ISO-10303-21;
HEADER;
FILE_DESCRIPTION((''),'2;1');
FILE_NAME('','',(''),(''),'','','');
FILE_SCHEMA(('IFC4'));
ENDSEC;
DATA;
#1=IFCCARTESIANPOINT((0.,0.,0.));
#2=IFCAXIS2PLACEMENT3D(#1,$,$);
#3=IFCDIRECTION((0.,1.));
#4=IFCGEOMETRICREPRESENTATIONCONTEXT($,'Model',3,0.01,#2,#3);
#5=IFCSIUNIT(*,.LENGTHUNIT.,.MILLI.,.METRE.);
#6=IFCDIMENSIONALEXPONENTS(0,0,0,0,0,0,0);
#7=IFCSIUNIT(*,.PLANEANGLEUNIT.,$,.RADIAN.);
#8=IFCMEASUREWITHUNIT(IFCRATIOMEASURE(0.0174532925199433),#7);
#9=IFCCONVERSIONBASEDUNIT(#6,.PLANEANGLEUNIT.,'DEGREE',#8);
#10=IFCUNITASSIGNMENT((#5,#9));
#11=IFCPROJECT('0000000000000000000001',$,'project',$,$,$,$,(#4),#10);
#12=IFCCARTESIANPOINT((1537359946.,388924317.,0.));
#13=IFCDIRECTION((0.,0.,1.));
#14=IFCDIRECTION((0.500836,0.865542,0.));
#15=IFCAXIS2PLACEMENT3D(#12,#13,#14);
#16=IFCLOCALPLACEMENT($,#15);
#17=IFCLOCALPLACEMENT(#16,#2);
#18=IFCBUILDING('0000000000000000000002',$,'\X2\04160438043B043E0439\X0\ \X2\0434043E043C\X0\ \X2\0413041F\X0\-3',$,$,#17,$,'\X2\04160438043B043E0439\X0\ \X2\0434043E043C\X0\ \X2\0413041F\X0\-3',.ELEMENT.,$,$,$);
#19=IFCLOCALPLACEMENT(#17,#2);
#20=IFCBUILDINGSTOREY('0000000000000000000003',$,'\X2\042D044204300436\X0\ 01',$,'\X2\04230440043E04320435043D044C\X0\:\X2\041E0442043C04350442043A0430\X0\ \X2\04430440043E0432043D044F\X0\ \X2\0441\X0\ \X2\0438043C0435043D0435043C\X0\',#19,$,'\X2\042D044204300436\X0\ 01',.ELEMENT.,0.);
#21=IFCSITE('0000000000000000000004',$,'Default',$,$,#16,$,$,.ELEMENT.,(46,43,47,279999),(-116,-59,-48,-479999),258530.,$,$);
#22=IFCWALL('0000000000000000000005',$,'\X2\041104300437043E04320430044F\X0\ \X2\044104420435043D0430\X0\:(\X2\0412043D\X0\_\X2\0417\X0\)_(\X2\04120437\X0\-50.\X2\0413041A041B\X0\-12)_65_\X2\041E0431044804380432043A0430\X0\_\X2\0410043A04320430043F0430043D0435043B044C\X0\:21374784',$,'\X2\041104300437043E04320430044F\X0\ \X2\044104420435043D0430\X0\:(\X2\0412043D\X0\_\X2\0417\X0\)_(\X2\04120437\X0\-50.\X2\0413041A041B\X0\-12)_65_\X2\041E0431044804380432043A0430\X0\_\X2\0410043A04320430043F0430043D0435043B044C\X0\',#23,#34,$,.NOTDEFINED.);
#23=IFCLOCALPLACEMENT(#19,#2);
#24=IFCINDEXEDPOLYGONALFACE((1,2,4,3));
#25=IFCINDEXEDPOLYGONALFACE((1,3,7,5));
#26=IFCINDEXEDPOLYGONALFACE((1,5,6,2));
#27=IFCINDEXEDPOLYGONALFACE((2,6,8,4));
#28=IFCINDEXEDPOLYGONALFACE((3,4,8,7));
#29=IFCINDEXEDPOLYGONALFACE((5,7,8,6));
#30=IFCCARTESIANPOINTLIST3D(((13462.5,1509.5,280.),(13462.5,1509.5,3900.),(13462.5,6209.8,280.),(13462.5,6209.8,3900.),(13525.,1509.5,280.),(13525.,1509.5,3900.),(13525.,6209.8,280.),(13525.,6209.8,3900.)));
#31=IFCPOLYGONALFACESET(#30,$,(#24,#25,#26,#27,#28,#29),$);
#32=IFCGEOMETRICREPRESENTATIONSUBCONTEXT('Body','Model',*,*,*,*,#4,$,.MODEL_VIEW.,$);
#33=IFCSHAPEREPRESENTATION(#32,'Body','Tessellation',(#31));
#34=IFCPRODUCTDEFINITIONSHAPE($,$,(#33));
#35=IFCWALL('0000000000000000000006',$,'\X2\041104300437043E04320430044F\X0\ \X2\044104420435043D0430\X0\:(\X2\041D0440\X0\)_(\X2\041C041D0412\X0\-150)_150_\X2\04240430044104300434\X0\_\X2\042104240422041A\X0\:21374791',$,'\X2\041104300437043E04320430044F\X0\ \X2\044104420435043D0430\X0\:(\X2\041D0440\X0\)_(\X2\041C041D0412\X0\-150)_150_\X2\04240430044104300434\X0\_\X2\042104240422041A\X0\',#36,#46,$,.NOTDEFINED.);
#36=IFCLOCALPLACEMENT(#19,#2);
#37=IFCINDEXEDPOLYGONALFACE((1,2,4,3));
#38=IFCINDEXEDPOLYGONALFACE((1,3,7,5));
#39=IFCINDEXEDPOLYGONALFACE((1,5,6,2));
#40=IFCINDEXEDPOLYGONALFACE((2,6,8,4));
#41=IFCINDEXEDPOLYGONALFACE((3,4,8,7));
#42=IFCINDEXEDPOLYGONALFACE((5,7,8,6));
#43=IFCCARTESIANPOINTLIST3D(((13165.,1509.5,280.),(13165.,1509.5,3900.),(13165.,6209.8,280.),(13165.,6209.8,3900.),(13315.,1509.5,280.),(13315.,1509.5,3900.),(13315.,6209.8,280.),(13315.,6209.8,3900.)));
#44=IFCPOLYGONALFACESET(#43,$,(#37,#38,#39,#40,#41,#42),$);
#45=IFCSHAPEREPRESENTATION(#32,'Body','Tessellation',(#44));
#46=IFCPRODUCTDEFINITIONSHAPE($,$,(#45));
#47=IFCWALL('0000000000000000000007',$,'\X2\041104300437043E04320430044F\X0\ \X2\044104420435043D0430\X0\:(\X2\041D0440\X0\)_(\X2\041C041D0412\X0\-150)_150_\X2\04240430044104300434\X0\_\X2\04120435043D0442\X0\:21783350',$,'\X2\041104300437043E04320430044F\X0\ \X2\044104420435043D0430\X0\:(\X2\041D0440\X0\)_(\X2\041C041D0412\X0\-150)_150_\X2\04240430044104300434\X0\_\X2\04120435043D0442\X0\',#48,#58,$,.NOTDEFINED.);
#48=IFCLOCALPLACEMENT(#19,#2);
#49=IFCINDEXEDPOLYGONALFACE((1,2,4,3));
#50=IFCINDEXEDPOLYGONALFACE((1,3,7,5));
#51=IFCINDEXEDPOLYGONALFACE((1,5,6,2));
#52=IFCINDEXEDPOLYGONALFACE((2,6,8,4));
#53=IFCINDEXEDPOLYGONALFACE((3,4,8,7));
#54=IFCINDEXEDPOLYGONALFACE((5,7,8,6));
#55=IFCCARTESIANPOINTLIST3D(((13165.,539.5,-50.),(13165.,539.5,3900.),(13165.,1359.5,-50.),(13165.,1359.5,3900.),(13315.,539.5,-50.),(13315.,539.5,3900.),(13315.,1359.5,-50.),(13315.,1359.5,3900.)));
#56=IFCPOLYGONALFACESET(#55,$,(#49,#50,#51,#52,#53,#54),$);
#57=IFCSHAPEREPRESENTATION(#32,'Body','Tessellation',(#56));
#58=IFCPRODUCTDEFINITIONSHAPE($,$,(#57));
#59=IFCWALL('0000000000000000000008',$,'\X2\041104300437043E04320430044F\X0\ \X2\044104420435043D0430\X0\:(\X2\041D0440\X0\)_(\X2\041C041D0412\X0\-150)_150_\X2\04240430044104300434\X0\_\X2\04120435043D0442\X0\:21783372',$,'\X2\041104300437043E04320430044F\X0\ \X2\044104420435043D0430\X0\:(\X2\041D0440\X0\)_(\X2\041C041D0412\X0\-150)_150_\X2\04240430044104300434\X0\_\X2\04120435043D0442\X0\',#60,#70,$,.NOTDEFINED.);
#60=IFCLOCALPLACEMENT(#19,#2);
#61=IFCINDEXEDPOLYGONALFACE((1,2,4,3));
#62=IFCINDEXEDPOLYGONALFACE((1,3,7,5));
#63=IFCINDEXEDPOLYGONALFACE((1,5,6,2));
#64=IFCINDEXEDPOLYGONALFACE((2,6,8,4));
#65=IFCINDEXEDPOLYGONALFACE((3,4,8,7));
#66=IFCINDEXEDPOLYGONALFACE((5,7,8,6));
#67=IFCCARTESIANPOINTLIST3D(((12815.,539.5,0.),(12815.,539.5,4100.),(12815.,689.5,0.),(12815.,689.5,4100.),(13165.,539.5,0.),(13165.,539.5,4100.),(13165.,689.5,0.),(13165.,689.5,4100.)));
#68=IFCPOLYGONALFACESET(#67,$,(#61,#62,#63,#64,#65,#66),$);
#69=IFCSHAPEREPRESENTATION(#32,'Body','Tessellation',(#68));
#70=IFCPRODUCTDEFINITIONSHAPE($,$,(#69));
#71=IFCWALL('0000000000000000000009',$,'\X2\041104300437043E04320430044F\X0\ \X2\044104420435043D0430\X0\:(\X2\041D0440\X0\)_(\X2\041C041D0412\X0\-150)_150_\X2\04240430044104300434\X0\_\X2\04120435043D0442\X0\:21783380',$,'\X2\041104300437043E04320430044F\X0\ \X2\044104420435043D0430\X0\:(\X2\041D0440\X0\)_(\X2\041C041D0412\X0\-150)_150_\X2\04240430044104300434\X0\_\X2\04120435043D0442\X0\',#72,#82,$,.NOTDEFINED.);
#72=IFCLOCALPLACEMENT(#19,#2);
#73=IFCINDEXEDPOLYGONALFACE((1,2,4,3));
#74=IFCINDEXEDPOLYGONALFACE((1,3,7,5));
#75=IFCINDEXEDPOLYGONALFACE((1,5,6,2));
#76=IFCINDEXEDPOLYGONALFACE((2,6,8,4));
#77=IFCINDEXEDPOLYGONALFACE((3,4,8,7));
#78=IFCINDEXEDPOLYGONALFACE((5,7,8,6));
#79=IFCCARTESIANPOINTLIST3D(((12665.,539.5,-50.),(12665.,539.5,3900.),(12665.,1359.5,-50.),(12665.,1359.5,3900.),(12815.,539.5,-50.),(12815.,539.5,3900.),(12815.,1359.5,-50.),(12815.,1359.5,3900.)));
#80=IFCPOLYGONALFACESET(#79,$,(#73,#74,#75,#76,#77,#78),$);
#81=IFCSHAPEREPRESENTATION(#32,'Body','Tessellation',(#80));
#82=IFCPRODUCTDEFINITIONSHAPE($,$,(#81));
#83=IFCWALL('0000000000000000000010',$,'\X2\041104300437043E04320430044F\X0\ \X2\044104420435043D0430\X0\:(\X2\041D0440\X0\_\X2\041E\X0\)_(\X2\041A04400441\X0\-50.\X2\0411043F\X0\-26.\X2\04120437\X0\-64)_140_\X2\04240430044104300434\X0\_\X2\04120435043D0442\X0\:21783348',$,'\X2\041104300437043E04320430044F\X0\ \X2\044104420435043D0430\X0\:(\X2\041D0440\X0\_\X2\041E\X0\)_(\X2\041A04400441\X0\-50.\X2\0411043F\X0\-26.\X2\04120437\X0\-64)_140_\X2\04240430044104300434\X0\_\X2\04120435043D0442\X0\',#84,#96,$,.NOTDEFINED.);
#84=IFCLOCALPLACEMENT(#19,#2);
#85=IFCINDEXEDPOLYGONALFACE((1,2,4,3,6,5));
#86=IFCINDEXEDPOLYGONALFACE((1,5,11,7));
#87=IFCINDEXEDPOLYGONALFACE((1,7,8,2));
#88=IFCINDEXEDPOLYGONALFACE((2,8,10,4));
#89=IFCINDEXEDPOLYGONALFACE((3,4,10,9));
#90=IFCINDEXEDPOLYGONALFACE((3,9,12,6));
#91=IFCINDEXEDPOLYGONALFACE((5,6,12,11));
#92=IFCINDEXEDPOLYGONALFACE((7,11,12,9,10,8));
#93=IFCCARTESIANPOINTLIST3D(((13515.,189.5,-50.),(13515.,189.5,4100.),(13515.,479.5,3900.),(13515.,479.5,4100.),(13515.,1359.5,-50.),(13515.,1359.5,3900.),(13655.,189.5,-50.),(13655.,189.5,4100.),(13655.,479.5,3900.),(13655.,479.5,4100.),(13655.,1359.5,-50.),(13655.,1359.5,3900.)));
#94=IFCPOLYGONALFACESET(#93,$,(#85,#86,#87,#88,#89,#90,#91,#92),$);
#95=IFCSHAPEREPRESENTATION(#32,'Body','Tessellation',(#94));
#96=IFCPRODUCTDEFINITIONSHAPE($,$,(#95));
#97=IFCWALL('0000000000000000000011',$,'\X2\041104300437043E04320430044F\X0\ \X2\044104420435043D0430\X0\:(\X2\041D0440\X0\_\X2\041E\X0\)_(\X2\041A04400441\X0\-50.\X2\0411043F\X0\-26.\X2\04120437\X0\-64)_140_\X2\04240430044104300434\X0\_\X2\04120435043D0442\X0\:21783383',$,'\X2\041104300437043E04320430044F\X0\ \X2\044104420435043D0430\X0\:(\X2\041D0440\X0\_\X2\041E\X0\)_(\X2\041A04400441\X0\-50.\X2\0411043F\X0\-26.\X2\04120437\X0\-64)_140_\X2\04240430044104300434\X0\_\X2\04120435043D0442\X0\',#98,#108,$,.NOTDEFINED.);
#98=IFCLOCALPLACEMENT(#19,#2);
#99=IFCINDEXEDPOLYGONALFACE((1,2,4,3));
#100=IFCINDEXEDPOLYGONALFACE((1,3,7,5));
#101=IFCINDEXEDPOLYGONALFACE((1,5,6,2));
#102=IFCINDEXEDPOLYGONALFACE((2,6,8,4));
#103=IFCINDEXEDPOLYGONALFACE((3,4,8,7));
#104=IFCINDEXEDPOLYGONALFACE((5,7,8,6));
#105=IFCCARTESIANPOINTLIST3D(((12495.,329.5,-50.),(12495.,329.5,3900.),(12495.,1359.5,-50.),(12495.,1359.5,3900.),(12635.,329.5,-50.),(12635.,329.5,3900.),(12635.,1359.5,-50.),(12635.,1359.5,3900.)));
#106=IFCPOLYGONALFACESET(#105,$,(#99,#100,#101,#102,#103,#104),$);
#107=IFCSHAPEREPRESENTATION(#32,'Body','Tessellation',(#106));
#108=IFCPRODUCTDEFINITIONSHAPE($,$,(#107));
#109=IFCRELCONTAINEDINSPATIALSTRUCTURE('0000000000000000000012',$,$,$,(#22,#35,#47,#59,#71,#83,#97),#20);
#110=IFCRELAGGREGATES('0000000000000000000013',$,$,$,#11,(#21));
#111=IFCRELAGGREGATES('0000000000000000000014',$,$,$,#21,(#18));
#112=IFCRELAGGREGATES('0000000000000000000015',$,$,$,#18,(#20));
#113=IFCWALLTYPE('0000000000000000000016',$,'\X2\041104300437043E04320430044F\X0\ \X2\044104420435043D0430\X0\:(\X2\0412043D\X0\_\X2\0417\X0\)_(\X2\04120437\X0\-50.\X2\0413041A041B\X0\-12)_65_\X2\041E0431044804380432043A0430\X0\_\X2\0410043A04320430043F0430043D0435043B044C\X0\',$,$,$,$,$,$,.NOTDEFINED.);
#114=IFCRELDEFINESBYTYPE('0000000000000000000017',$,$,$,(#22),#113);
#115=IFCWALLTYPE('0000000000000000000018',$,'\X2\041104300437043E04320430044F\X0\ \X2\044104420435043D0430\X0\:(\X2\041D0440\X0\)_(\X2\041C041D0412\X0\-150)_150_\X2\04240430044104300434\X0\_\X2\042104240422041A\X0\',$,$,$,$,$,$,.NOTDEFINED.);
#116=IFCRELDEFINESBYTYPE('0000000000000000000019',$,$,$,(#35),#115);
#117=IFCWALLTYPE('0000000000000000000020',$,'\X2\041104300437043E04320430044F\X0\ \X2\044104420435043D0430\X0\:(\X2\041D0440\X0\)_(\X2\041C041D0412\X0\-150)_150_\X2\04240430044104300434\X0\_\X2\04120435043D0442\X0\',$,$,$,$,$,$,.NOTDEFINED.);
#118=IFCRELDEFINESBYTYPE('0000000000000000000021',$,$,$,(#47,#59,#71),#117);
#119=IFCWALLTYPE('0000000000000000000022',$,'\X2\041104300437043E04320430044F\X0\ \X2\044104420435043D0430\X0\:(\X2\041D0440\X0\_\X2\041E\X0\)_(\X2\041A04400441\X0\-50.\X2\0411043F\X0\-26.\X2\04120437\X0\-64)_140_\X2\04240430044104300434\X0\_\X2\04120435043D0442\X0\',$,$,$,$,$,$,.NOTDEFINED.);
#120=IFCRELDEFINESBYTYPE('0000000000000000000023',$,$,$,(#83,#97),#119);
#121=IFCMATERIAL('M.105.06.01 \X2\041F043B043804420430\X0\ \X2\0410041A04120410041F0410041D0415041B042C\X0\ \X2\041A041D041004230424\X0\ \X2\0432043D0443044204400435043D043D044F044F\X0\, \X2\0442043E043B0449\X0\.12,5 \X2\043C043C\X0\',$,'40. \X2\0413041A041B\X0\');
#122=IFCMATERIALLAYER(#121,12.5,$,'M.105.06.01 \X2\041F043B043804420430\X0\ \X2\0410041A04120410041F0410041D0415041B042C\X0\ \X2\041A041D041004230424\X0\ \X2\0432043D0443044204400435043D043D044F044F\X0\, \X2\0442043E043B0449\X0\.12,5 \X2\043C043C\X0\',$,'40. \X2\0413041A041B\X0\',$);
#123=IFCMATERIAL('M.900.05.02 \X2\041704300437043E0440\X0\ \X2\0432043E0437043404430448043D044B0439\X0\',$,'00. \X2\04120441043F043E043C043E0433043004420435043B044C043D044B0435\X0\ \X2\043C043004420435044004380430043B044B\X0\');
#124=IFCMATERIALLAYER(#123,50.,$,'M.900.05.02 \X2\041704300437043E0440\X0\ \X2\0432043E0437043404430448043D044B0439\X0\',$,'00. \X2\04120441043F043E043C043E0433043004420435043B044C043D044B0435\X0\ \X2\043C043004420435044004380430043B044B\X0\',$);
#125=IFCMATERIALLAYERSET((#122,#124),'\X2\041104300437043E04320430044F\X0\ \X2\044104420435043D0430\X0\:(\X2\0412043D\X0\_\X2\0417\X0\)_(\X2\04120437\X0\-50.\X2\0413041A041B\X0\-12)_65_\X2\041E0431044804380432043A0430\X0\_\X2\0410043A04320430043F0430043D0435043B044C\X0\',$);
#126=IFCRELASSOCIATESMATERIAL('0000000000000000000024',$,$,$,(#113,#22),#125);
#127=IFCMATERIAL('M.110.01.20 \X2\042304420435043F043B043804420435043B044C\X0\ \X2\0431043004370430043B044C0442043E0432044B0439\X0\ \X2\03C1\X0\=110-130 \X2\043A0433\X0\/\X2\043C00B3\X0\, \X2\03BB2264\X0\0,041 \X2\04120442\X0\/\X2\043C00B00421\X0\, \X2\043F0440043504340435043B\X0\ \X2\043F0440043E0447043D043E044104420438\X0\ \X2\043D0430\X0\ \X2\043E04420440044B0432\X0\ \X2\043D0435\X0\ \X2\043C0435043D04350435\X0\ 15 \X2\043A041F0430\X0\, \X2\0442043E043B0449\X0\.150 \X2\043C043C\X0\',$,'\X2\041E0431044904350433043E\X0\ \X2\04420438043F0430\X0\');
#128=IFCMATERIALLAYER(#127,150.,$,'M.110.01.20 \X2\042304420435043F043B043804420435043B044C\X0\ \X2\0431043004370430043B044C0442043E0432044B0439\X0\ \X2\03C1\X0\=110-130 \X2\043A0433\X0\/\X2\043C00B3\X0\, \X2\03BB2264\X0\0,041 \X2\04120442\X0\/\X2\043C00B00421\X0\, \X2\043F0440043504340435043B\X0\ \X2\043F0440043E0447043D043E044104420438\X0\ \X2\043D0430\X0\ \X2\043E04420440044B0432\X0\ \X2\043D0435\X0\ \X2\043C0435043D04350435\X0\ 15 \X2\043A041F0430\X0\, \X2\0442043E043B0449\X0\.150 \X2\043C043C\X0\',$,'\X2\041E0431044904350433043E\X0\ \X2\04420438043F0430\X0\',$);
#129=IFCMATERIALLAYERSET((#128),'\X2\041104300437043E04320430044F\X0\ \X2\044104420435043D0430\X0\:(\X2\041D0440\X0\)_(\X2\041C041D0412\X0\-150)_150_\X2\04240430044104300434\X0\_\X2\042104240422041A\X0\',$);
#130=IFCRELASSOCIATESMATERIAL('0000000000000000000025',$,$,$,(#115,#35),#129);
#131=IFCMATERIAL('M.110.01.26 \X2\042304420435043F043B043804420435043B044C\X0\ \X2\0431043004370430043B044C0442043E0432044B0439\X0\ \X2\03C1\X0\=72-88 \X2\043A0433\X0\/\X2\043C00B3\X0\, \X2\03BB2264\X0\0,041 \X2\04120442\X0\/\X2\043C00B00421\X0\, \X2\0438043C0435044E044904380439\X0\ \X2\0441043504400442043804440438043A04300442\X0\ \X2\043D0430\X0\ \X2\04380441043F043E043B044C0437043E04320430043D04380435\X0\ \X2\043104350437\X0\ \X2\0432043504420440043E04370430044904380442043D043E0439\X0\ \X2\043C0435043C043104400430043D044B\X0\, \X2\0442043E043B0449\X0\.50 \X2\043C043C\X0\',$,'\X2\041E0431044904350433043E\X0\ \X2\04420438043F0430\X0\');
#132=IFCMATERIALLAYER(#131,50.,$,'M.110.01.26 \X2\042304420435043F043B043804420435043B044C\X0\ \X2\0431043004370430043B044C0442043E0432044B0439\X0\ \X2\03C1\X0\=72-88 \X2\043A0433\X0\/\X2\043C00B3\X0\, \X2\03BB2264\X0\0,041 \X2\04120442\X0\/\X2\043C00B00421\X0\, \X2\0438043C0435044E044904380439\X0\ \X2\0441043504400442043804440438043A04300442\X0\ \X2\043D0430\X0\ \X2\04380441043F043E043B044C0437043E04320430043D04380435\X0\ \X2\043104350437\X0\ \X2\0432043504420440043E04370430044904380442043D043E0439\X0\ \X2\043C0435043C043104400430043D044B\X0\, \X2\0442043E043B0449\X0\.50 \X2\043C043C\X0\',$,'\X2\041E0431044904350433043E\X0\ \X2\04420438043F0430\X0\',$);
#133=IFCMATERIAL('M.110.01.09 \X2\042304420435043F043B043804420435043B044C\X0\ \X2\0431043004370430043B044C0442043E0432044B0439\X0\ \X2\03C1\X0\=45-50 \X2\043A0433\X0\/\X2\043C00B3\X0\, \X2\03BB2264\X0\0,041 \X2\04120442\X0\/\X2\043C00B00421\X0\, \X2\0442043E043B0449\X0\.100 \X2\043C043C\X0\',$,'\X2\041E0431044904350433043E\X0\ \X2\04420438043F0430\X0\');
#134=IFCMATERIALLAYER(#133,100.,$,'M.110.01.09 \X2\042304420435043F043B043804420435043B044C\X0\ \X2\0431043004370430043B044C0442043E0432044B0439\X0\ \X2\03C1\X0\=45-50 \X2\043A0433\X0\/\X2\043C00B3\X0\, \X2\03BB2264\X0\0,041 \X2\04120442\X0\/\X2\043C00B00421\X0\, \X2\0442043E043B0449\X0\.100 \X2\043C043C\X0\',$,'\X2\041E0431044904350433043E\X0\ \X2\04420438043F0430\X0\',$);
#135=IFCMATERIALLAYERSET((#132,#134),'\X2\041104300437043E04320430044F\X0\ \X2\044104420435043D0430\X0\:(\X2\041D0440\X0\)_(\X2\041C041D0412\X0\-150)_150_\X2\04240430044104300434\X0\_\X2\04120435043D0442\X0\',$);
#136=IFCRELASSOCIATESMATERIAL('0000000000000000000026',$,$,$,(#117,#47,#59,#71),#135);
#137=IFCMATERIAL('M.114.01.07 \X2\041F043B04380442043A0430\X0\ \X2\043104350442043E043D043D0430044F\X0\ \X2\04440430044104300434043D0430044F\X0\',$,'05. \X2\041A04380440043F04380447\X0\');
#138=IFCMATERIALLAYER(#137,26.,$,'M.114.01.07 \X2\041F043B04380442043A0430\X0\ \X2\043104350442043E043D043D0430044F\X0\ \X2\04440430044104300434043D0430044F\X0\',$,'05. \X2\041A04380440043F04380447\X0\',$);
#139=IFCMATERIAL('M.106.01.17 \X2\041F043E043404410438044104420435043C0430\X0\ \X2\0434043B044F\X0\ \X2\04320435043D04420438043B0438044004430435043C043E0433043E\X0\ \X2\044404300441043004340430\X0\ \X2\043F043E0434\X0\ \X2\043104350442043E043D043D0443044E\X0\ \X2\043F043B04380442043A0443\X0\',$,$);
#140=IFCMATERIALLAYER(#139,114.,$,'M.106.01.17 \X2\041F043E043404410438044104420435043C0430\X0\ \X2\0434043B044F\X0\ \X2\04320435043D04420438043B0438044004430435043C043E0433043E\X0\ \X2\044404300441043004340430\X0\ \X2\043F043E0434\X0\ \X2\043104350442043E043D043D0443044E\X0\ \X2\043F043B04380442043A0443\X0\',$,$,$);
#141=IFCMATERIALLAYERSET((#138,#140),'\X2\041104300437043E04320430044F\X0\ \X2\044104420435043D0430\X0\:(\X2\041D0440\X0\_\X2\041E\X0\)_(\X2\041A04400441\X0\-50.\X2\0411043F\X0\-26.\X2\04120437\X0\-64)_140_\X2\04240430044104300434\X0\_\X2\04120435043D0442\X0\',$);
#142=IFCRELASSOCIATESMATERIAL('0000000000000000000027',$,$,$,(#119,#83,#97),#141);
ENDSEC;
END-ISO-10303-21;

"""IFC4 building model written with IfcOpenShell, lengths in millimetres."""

from ifc_helpers import new_model, entity, si_unit, converted_unit, direction, frame, frame_2d, origin, place, context, subcontext, project, spatial, rectangle, extrude, material, layer, layer_set, layer_usage, type_object, element, save


model = new_model("IFC4")

# Units and contexts
model_context = context("Model", 3, precision=0.01, world=origin(), true_north=direction((0.0, 1.0)))
body_context = subcontext(model_context, "Body", "Model", "MODEL_VIEW")
ifc_project = project(units=[si_unit("LENGTHUNIT", "METRE", prefix="MILLI"), converted_unit("PLANEANGLEUNIT", "DEGREE", entity("IfcRatioMeasure", 0.0174532925199433), si_unit("PLANEANGLEUNIT", "RADIAN"), dimensions=[0, 0, 0, 0, 0, 0, 0])], contexts=[model_context])

# Site, building, storey
site_placement = place(None, frame((1537359946.0, 388924317.0, 0.0), z_axis=(0.0, 0.0, 1.0), x_axis=(0.500836, 0.865542, 0.0)))
site = spatial("IfcSite", under=ifc_project, at=site_placement, Name="Default", CompositionType="ELEMENT", RefLatitude=(46, 43, 47, 279999), RefLongitude=(-116, -59, -48, -479999), RefElevation=258530.0)
building_placement = place(site_placement, origin())
building = spatial("IfcBuilding", under=site, at=building_placement, Name="Жилой дом ГП-3", LongName="Жилой дом ГП-3", CompositionType="ELEMENT")
storey_placement = place(building_placement, origin())
storey = spatial("IfcBuildingStorey", under=building, at=storey_placement, Name="Этаж 01", ObjectType="Уровень:Отметка уровня с именем", LongName="Этаж 01", CompositionType="ELEMENT", Elevation=0.0)

# Walls
ifc_material_1 = material(Name="M.105.06.01 Плита АКВАПАНЕЛЬ КНАУФ внутренняя, толщ.12,5 мм", Category="40. ГКЛ")
ifc_layer_1 = layer(ifc_material_1, 12.5, Name="M.105.06.01 Плита АКВАПАНЕЛЬ КНАУФ внутренняя, толщ.12,5 мм", Category="40. ГКЛ")
ifc_material_2 = material(Name="M.900.05.02 Зазор воздушный", Category="00. Вспомогательные материалы")
ifc_layer_2 = layer(ifc_material_2, 50.0, Name="M.900.05.02 Зазор воздушный", Category="00. Вспомогательные материалы")
ifc_layer_set_1 = layer_set([ifc_layer_1, ifc_layer_2], Name="Базовая стена:(Вн_З)_(Вз-50.ГКЛ-12)_65_Обшивка_Аквапанель")
ifc_layer_usage_1 = layer_usage(ifc_layer_set_1, "AXIS2", "POSITIVE", -31.2)
wall_type_1 = type_object("IfcWallType", Name="Базовая стена:(Вн_З)_(Вз-50.ГКЛ-12)_65_Обшивка_Аквапанель", PredefinedType="NOTDEFINED", material=ifc_layer_set_1)
wall_1_placement = place(storey_placement, frame((13493.7, 1509.5, 280.0), z_axis=(0.0, 0.0, 1.0), x_axis=(0.0, 1.0, 0.0)))
element("IfcWall", 1, at=wall_1_placement, inside=storey, type_object=wall_type_1, material=ifc_layer_usage_1, Name="Базовая стена:(Вн_З)_(Вз-50.ГКЛ-12)_65_Обшивка_Аквапанель:21374784", ObjectType="Базовая стена:(Вн_З)_(Вз-50.ГКЛ-12)_65_Обшивка_Аквапанель", PredefinedType="NOTDEFINED", context=body_context, shape_type="SweptSolid", body=[
    extrude(rectangle(XDim=4700.2, YDim=62.5, at=frame_2d((2350.1, 0.0), x_axis=(-1.0, 0.0))), origin(), (0.0, 0.0, 1.0), 3620.0),
])
ifc_material_3 = material(Name="M.110.01.20 Утеплитель базальтовый ρ=110-130 кг/м³, λ≤0,041 Вт/м°С, предел прочности на отрыв не менее 15 кПа, толщ.150 мм", Category="Общего типа")
ifc_layer_3 = layer(ifc_material_3, 150.0, Name="M.110.01.20 Утеплитель базальтовый ρ=110-130 кг/м³, λ≤0,041 Вт/м°С, предел прочности на отрыв не менее 15 кПа, толщ.150 мм", Category="Общего типа")
ifc_layer_set_2 = layer_set([ifc_layer_3], Name="Базовая стена:(Нр)_(МНВ-150)_150_Фасад_СФТК")
ifc_layer_usage_2 = layer_usage(ifc_layer_set_2, "AXIS2", "NEGATIVE", 75.0)
wall_type_2 = type_object("IfcWallType", Name="Базовая стена:(Нр)_(МНВ-150)_150_Фасад_СФТК", PredefinedType="NOTDEFINED", material=ifc_layer_set_2)
wall_2_placement = place(storey_placement, frame((13240.0, 1509.5, 280.0), z_axis=(0.0, 0.0, 1.0), x_axis=(0.0, 1.0, 0.0)))
element("IfcWall", 2, at=wall_2_placement, inside=storey, type_object=wall_type_2, material=ifc_layer_usage_2, Name="Базовая стена:(Нр)_(МНВ-150)_150_Фасад_СФТК:21374791", ObjectType="Базовая стена:(Нр)_(МНВ-150)_150_Фасад_СФТК", PredefinedType="NOTDEFINED", context=body_context, shape_type="SweptSolid", body=[
    extrude(rectangle(XDim=4700.2, YDim=150.0, at=frame_2d((2350.1, 0.0), x_axis=(-1.0, 0.0))), origin(), (0.0, 0.0, 1.0), 3620.0),
])
ifc_material_4 = material(Name="M.110.01.26 Утеплитель базальтовый ρ=72-88 кг/м³, λ≤0,041 Вт/м°С, имеющий сертификат на использование без ветрозащитной мембраны, толщ.50 мм", Category="Общего типа")
ifc_layer_4 = layer(ifc_material_4, 50.0, Name="M.110.01.26 Утеплитель базальтовый ρ=72-88 кг/м³, λ≤0,041 Вт/м°С, имеющий сертификат на использование без ветрозащитной мембраны, толщ.50 мм", Category="Общего типа")
ifc_material_5 = material(Name="M.110.01.09 Утеплитель базальтовый ρ=45-50 кг/м³, λ≤0,041 Вт/м°С, толщ.100 мм", Category="Общего типа")
ifc_layer_5 = layer(ifc_material_5, 100.0, Name="M.110.01.09 Утеплитель базальтовый ρ=45-50 кг/м³, λ≤0,041 Вт/м°С, толщ.100 мм", Category="Общего типа")
ifc_layer_set_3 = layer_set([ifc_layer_4, ifc_layer_5], Name="Базовая стена:(Нр)_(МНВ-150)_150_Фасад_Вент")
ifc_layer_usage_3 = layer_usage(ifc_layer_set_3, "AXIS2", "NEGATIVE", 75.0)
wall_type_3 = type_object("IfcWallType", Name="Базовая стена:(Нр)_(МНВ-150)_150_Фасад_Вент", PredefinedType="NOTDEFINED", material=ifc_layer_set_3)
wall_3_placement = place(storey_placement, frame((13240.0, 1359.5, -50.0), z_axis=(0.0, 0.0, 1.0), x_axis=(0.0, -1.0, 0.0)))
element("IfcWall", 3, at=wall_3_placement, inside=storey, type_object=wall_type_3, material=ifc_layer_usage_3, Name="Базовая стена:(Нр)_(МНВ-150)_150_Фасад_Вент:21783350", ObjectType="Базовая стена:(Нр)_(МНВ-150)_150_Фасад_Вент", PredefinedType="NOTDEFINED", context=body_context, shape_type="SweptSolid", body=[
    extrude(rectangle(XDim=820.0, YDim=150.0, at=frame_2d((410.0, 0.0), x_axis=(-1.0, 0.0))), origin(), (0.0, 0.0, 1.0), 3950.0),
])
ifc_layer_usage_4 = layer_usage(ifc_layer_set_3, "AXIS2", "NEGATIVE", 75.0)
wall_4_placement = place(storey_placement, frame((13165.0, 614.5, 0.0), z_axis=(0.0, 0.0, 1.0), x_axis=(-1.0, 0.0, 0.0)))
element("IfcWall", 4, at=wall_4_placement, inside=storey, type_object=wall_type_3, material=ifc_layer_usage_4, Name="Базовая стена:(Нр)_(МНВ-150)_150_Фасад_Вент:21783372", ObjectType="Базовая стена:(Нр)_(МНВ-150)_150_Фасад_Вент", PredefinedType="NOTDEFINED", context=body_context, shape_type="SweptSolid", body=[
    extrude(rectangle(XDim=350.0, YDim=150.0, at=frame_2d((175.0, 0.0), x_axis=(-1.0, 0.0))), origin(), (0.0, 0.0, 1.0), 4100.0),
])
ifc_layer_usage_5 = layer_usage(ifc_layer_set_3, "AXIS2", "POSITIVE", -75.0)
wall_5_placement = place(storey_placement, frame((12740.0, 1359.5, -50.0), z_axis=(0.0, 0.0, 1.0), x_axis=(0.0, -1.0, 0.0)))
element("IfcWall", 5, at=wall_5_placement, inside=storey, type_object=wall_type_3, material=ifc_layer_usage_5, Name="Базовая стена:(Нр)_(МНВ-150)_150_Фасад_Вент:21783380", ObjectType="Базовая стена:(Нр)_(МНВ-150)_150_Фасад_Вент", PredefinedType="NOTDEFINED", context=body_context, shape_type="SweptSolid", body=[
    extrude(rectangle(XDim=820.0, YDim=150.0, at=frame_2d((410.0, 0.0), x_axis=(-1.0, 0.0))), origin(), (0.0, 0.0, 1.0), 3950.0),
])

# Wall, opening
ifc_material_6 = material(Name="M.114.01.07 Плитка бетонная фасадная", Category="05. Кирпич")
ifc_layer_6 = layer(ifc_material_6, 26.0, Name="M.114.01.07 Плитка бетонная фасадная", Category="05. Кирпич")
ifc_material_7 = material(Name="M.106.01.17 Подсистема для вентилируемого фасада под бетонную плитку")
ifc_layer_7 = layer(ifc_material_7, 114.0, Name="M.106.01.17 Подсистема для вентилируемого фасада под бетонную плитку")
ifc_layer_set_4 = layer_set([ifc_layer_6, ifc_layer_7], Name="Базовая стена:(Нр_О)_(Крс-50.Бп-26.Вз-64)_140_Фасад_Вент")
ifc_layer_usage_6 = layer_usage(ifc_layer_set_4, "AXIS2", "POSITIVE", -70.0)
wall_type_4 = type_object("IfcWallType", Name="Базовая стена:(Нр_О)_(Крс-50.Бп-26.Вз-64)_140_Фасад_Вент", PredefinedType="NOTDEFINED", material=ifc_layer_set_4)
wall_6_placement = place(storey_placement, frame((13585.0, 189.5, -50.0), z_axis=(0.0, 0.0, 1.0), x_axis=(0.0, 1.0, 0.0)))
wall_6 = element("IfcWall", 6, at=wall_6_placement, inside=storey, type_object=wall_type_4, material=ifc_layer_usage_6, Name="Базовая стена:(Нр_О)_(Крс-50.Бп-26.Вз-64)_140_Фасад_Вент:21783348", ObjectType="Базовая стена:(Нр_О)_(Крс-50.Бп-26.Вз-64)_140_Фасад_Вент", PredefinedType="NOTDEFINED", context=body_context, shape_type="SweptSolid", body=[
    extrude(rectangle(XDim=1170.0, YDim=140.0, at=frame_2d((585.0, 0.0), x_axis=(-1.0, 0.0))), origin(), (0.0, 0.0, 1.0), 4150.0),
])
opening_1_placement = place(wall_6_placement, origin())
element("IfcOpeningElement", 7, at=opening_1_placement, cuts=wall_6, ObjectType="Opening", PredefinedType="OPENING", context=body_context, shape_type="SweptSolid", body=[
    extrude(rectangle(XDim=200.0, YDim=880.0, at=frame_2d((0.0, 0.0), x_axis=(1.0, 0.0))), frame((730.0, 70.0, 4050.0), z_axis=(0.0, -1.0, 0.0), x_axis=(0.0, 0.0, 1.0)), (0.0, 0.0, 1.0), 140.0),
])

# Wall
ifc_layer_usage_7 = layer_usage(ifc_layer_set_4, "AXIS2", "POSITIVE", -70.0)
wall_7_placement = place(storey_placement, frame((12565.0, 1359.5, -50.0), z_axis=(0.0, 0.0, 1.0), x_axis=(0.0, -1.0, 0.0)))
element("IfcWall", 8, at=wall_7_placement, inside=storey, type_object=wall_type_4, material=ifc_layer_usage_7, Name="Базовая стена:(Нр_О)_(Крс-50.Бп-26.Вз-64)_140_Фасад_Вент:21783383", ObjectType="Базовая стена:(Нр_О)_(Крс-50.Бп-26.Вз-64)_140_Фасад_Вент", PredefinedType="NOTDEFINED", context=body_context, shape_type="SweptSolid", body=[
    extrude(rectangle(XDim=1030.0, YDim=140.0, at=frame_2d((515.0, 0.0), x_axis=(-1.0, 0.0))), origin(), (0.0, 0.0, 1.0), 3950.0),
])

save(model, "model.ifc")
